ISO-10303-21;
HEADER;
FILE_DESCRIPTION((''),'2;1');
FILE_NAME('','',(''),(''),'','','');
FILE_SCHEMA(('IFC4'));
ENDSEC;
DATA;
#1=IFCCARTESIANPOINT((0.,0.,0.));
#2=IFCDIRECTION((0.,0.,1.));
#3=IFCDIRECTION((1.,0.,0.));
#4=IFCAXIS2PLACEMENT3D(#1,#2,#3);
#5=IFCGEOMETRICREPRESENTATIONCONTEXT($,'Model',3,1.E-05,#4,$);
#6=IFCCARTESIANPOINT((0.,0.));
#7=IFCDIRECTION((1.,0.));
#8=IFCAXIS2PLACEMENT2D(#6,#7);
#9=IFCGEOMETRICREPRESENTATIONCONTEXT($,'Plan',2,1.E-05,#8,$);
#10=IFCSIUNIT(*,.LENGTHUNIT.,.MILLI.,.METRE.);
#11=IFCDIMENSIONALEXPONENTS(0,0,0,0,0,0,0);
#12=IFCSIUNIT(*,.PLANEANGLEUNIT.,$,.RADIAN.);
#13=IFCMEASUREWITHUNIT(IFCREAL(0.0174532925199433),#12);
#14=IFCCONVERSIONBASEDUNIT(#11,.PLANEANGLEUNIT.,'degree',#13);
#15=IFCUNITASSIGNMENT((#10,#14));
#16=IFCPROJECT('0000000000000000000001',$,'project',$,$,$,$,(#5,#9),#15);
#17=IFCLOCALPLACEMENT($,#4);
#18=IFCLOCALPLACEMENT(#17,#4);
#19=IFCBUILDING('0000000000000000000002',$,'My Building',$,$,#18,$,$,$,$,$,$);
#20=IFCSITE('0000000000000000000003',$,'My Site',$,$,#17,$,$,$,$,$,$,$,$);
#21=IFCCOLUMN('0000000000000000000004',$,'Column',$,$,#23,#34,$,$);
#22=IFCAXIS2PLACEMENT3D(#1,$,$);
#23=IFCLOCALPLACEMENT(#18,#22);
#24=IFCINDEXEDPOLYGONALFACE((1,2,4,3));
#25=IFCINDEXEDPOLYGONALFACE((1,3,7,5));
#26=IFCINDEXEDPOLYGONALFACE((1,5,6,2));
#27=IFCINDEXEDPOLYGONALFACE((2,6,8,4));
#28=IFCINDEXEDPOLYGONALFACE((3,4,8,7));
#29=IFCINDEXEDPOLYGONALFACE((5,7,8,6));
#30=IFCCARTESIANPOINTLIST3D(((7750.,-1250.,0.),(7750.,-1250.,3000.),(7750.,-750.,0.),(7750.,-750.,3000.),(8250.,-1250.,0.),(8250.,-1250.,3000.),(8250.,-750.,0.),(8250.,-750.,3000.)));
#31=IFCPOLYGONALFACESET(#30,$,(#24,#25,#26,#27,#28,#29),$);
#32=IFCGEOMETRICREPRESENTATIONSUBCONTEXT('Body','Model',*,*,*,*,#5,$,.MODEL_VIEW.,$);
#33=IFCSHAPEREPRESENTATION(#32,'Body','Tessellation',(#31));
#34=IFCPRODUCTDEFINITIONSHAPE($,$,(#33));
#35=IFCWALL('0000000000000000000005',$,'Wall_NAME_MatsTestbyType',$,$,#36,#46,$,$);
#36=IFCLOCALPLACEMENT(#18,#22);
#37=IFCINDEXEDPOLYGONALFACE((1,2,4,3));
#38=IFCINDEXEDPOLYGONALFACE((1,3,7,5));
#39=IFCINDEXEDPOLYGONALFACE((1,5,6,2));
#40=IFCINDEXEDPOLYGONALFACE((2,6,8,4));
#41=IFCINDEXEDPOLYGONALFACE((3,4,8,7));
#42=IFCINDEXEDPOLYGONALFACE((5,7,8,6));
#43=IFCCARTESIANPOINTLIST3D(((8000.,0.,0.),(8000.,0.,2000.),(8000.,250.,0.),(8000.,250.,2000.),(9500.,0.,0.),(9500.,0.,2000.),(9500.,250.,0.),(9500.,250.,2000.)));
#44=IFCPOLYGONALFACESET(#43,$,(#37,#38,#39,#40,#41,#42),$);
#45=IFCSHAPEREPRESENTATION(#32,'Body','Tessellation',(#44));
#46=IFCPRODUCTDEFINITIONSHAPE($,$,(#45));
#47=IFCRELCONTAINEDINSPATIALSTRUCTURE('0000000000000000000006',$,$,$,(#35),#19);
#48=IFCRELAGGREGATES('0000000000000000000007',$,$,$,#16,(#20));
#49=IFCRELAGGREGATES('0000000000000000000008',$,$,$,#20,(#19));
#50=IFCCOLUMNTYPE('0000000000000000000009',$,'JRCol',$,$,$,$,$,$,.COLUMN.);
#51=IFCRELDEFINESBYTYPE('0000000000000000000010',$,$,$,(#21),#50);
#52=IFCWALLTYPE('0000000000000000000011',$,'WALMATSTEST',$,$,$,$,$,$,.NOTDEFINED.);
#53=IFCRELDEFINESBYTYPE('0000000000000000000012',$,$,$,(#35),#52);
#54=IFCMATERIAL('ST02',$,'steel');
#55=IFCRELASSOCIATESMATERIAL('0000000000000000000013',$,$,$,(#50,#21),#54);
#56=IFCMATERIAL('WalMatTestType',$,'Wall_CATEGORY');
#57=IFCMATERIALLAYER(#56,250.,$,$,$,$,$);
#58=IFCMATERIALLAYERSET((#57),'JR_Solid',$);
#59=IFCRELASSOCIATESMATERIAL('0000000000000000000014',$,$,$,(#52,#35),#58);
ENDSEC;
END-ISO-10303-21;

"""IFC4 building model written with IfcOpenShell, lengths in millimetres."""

from ifc_helpers import new_model, entity, si_unit, converted_unit, frame, origin_with_axes, origin_2d_with_axis, place, context, subcontext, project, spatial, indexed_curve, rectangle, outline, extrude, material, layer, layer_set, layer_usage, material_profile, profile_set, profile_usage, type_object, element, save


model = new_model("IFC4")

# Units and contexts
model_context = context("Model", 3, precision=1e-05, world=origin_with_axes())
plan_context = context("Plan", 2, precision=1e-05, world=origin_2d_with_axis())
body_context = subcontext(model_context, "Body", "Model", "MODEL_VIEW")
ifc_project = project(units=[si_unit("LENGTHUNIT", "METRE", prefix="MILLI"), converted_unit("PLANEANGLEUNIT", "degree", entity("IfcReal", 0.0174532925199433), si_unit("PLANEANGLEUNIT", "RADIAN"), dimensions=[0, 0, 0, 0, 0, 0, 0])], contexts=[model_context, plan_context])

# Column
ifc_material_1 = material(Name="ST02", Category="steel")
ifc_material_profile = material_profile(ifc_material_1, rectangle(XDim=500.0, YDim=500.0))
ifc_profile_set = profile_set([ifc_material_profile])
ifc_profile_usage = profile_usage(ifc_profile_set, cardinal=5)
column_type = type_object("IfcColumnType", Name="JRCol", PredefinedType="COLUMN", material=ifc_profile_set)
column_placement = place(None, frame((8000.0, -1000.0, 0.0), z_axis=(0.0, 0.0, 1.0), x_axis=(1.0, 0.0, 0.0)))
element("IfcColumn", 1, at=column_placement, type_object=column_type, material=ifc_profile_usage, Name="Column", context=body_context, shape_type="SweptSolid", body=[
    extrude(rectangle(XDim=500.0, YDim=500.0), origin_with_axes(), (0.0, 0.0, 1.0), 3000.0),
])

# Site, building
site_placement = place(None, origin_with_axes())
site = spatial("IfcSite", under=ifc_project, at=site_placement, Name="My Site")
building_placement = place(site_placement, origin_with_axes())
building = spatial("IfcBuilding", under=site, at=building_placement, Name="My Building")

# Wall
ifc_material_2 = material(Name="WalMatTestType", Category="Wall_CATEGORY")
ifc_layer = layer(ifc_material_2, 250.0)
ifc_layer_set = layer_set([ifc_layer], Name="JR_Solid")
ifc_layer_usage = layer_usage(ifc_layer_set, "AXIS2", "POSITIVE", 0.0)
wall_type = type_object("IfcWallType", Name="WALMATSTEST", PredefinedType="NOTDEFINED", material=ifc_layer_set)
wall_placement = place(building_placement, frame((8000.0, 0.0, 0.0), z_axis=(0.0, 0.0, 1.0), x_axis=(1.0, 0.0, 0.0)))
element("IfcWall", 2, at=wall_placement, inside=building, type_object=wall_type, material=ifc_layer_usage, Name="Wall_NAME_MatsTestbyType", context=body_context, shape_type="SweptSolid", body=[
    extrude(outline(indexed_curve([(0.0, 0.0), (0.0, 250.0), (1500.0, 250.0), (1500.0, 0.0), (0.0, 0.0)], self_intersect=False)), origin_with_axes(), (0.0, 0.0, 1.0), 2000.0),
])

save(model, "model.ifc")
